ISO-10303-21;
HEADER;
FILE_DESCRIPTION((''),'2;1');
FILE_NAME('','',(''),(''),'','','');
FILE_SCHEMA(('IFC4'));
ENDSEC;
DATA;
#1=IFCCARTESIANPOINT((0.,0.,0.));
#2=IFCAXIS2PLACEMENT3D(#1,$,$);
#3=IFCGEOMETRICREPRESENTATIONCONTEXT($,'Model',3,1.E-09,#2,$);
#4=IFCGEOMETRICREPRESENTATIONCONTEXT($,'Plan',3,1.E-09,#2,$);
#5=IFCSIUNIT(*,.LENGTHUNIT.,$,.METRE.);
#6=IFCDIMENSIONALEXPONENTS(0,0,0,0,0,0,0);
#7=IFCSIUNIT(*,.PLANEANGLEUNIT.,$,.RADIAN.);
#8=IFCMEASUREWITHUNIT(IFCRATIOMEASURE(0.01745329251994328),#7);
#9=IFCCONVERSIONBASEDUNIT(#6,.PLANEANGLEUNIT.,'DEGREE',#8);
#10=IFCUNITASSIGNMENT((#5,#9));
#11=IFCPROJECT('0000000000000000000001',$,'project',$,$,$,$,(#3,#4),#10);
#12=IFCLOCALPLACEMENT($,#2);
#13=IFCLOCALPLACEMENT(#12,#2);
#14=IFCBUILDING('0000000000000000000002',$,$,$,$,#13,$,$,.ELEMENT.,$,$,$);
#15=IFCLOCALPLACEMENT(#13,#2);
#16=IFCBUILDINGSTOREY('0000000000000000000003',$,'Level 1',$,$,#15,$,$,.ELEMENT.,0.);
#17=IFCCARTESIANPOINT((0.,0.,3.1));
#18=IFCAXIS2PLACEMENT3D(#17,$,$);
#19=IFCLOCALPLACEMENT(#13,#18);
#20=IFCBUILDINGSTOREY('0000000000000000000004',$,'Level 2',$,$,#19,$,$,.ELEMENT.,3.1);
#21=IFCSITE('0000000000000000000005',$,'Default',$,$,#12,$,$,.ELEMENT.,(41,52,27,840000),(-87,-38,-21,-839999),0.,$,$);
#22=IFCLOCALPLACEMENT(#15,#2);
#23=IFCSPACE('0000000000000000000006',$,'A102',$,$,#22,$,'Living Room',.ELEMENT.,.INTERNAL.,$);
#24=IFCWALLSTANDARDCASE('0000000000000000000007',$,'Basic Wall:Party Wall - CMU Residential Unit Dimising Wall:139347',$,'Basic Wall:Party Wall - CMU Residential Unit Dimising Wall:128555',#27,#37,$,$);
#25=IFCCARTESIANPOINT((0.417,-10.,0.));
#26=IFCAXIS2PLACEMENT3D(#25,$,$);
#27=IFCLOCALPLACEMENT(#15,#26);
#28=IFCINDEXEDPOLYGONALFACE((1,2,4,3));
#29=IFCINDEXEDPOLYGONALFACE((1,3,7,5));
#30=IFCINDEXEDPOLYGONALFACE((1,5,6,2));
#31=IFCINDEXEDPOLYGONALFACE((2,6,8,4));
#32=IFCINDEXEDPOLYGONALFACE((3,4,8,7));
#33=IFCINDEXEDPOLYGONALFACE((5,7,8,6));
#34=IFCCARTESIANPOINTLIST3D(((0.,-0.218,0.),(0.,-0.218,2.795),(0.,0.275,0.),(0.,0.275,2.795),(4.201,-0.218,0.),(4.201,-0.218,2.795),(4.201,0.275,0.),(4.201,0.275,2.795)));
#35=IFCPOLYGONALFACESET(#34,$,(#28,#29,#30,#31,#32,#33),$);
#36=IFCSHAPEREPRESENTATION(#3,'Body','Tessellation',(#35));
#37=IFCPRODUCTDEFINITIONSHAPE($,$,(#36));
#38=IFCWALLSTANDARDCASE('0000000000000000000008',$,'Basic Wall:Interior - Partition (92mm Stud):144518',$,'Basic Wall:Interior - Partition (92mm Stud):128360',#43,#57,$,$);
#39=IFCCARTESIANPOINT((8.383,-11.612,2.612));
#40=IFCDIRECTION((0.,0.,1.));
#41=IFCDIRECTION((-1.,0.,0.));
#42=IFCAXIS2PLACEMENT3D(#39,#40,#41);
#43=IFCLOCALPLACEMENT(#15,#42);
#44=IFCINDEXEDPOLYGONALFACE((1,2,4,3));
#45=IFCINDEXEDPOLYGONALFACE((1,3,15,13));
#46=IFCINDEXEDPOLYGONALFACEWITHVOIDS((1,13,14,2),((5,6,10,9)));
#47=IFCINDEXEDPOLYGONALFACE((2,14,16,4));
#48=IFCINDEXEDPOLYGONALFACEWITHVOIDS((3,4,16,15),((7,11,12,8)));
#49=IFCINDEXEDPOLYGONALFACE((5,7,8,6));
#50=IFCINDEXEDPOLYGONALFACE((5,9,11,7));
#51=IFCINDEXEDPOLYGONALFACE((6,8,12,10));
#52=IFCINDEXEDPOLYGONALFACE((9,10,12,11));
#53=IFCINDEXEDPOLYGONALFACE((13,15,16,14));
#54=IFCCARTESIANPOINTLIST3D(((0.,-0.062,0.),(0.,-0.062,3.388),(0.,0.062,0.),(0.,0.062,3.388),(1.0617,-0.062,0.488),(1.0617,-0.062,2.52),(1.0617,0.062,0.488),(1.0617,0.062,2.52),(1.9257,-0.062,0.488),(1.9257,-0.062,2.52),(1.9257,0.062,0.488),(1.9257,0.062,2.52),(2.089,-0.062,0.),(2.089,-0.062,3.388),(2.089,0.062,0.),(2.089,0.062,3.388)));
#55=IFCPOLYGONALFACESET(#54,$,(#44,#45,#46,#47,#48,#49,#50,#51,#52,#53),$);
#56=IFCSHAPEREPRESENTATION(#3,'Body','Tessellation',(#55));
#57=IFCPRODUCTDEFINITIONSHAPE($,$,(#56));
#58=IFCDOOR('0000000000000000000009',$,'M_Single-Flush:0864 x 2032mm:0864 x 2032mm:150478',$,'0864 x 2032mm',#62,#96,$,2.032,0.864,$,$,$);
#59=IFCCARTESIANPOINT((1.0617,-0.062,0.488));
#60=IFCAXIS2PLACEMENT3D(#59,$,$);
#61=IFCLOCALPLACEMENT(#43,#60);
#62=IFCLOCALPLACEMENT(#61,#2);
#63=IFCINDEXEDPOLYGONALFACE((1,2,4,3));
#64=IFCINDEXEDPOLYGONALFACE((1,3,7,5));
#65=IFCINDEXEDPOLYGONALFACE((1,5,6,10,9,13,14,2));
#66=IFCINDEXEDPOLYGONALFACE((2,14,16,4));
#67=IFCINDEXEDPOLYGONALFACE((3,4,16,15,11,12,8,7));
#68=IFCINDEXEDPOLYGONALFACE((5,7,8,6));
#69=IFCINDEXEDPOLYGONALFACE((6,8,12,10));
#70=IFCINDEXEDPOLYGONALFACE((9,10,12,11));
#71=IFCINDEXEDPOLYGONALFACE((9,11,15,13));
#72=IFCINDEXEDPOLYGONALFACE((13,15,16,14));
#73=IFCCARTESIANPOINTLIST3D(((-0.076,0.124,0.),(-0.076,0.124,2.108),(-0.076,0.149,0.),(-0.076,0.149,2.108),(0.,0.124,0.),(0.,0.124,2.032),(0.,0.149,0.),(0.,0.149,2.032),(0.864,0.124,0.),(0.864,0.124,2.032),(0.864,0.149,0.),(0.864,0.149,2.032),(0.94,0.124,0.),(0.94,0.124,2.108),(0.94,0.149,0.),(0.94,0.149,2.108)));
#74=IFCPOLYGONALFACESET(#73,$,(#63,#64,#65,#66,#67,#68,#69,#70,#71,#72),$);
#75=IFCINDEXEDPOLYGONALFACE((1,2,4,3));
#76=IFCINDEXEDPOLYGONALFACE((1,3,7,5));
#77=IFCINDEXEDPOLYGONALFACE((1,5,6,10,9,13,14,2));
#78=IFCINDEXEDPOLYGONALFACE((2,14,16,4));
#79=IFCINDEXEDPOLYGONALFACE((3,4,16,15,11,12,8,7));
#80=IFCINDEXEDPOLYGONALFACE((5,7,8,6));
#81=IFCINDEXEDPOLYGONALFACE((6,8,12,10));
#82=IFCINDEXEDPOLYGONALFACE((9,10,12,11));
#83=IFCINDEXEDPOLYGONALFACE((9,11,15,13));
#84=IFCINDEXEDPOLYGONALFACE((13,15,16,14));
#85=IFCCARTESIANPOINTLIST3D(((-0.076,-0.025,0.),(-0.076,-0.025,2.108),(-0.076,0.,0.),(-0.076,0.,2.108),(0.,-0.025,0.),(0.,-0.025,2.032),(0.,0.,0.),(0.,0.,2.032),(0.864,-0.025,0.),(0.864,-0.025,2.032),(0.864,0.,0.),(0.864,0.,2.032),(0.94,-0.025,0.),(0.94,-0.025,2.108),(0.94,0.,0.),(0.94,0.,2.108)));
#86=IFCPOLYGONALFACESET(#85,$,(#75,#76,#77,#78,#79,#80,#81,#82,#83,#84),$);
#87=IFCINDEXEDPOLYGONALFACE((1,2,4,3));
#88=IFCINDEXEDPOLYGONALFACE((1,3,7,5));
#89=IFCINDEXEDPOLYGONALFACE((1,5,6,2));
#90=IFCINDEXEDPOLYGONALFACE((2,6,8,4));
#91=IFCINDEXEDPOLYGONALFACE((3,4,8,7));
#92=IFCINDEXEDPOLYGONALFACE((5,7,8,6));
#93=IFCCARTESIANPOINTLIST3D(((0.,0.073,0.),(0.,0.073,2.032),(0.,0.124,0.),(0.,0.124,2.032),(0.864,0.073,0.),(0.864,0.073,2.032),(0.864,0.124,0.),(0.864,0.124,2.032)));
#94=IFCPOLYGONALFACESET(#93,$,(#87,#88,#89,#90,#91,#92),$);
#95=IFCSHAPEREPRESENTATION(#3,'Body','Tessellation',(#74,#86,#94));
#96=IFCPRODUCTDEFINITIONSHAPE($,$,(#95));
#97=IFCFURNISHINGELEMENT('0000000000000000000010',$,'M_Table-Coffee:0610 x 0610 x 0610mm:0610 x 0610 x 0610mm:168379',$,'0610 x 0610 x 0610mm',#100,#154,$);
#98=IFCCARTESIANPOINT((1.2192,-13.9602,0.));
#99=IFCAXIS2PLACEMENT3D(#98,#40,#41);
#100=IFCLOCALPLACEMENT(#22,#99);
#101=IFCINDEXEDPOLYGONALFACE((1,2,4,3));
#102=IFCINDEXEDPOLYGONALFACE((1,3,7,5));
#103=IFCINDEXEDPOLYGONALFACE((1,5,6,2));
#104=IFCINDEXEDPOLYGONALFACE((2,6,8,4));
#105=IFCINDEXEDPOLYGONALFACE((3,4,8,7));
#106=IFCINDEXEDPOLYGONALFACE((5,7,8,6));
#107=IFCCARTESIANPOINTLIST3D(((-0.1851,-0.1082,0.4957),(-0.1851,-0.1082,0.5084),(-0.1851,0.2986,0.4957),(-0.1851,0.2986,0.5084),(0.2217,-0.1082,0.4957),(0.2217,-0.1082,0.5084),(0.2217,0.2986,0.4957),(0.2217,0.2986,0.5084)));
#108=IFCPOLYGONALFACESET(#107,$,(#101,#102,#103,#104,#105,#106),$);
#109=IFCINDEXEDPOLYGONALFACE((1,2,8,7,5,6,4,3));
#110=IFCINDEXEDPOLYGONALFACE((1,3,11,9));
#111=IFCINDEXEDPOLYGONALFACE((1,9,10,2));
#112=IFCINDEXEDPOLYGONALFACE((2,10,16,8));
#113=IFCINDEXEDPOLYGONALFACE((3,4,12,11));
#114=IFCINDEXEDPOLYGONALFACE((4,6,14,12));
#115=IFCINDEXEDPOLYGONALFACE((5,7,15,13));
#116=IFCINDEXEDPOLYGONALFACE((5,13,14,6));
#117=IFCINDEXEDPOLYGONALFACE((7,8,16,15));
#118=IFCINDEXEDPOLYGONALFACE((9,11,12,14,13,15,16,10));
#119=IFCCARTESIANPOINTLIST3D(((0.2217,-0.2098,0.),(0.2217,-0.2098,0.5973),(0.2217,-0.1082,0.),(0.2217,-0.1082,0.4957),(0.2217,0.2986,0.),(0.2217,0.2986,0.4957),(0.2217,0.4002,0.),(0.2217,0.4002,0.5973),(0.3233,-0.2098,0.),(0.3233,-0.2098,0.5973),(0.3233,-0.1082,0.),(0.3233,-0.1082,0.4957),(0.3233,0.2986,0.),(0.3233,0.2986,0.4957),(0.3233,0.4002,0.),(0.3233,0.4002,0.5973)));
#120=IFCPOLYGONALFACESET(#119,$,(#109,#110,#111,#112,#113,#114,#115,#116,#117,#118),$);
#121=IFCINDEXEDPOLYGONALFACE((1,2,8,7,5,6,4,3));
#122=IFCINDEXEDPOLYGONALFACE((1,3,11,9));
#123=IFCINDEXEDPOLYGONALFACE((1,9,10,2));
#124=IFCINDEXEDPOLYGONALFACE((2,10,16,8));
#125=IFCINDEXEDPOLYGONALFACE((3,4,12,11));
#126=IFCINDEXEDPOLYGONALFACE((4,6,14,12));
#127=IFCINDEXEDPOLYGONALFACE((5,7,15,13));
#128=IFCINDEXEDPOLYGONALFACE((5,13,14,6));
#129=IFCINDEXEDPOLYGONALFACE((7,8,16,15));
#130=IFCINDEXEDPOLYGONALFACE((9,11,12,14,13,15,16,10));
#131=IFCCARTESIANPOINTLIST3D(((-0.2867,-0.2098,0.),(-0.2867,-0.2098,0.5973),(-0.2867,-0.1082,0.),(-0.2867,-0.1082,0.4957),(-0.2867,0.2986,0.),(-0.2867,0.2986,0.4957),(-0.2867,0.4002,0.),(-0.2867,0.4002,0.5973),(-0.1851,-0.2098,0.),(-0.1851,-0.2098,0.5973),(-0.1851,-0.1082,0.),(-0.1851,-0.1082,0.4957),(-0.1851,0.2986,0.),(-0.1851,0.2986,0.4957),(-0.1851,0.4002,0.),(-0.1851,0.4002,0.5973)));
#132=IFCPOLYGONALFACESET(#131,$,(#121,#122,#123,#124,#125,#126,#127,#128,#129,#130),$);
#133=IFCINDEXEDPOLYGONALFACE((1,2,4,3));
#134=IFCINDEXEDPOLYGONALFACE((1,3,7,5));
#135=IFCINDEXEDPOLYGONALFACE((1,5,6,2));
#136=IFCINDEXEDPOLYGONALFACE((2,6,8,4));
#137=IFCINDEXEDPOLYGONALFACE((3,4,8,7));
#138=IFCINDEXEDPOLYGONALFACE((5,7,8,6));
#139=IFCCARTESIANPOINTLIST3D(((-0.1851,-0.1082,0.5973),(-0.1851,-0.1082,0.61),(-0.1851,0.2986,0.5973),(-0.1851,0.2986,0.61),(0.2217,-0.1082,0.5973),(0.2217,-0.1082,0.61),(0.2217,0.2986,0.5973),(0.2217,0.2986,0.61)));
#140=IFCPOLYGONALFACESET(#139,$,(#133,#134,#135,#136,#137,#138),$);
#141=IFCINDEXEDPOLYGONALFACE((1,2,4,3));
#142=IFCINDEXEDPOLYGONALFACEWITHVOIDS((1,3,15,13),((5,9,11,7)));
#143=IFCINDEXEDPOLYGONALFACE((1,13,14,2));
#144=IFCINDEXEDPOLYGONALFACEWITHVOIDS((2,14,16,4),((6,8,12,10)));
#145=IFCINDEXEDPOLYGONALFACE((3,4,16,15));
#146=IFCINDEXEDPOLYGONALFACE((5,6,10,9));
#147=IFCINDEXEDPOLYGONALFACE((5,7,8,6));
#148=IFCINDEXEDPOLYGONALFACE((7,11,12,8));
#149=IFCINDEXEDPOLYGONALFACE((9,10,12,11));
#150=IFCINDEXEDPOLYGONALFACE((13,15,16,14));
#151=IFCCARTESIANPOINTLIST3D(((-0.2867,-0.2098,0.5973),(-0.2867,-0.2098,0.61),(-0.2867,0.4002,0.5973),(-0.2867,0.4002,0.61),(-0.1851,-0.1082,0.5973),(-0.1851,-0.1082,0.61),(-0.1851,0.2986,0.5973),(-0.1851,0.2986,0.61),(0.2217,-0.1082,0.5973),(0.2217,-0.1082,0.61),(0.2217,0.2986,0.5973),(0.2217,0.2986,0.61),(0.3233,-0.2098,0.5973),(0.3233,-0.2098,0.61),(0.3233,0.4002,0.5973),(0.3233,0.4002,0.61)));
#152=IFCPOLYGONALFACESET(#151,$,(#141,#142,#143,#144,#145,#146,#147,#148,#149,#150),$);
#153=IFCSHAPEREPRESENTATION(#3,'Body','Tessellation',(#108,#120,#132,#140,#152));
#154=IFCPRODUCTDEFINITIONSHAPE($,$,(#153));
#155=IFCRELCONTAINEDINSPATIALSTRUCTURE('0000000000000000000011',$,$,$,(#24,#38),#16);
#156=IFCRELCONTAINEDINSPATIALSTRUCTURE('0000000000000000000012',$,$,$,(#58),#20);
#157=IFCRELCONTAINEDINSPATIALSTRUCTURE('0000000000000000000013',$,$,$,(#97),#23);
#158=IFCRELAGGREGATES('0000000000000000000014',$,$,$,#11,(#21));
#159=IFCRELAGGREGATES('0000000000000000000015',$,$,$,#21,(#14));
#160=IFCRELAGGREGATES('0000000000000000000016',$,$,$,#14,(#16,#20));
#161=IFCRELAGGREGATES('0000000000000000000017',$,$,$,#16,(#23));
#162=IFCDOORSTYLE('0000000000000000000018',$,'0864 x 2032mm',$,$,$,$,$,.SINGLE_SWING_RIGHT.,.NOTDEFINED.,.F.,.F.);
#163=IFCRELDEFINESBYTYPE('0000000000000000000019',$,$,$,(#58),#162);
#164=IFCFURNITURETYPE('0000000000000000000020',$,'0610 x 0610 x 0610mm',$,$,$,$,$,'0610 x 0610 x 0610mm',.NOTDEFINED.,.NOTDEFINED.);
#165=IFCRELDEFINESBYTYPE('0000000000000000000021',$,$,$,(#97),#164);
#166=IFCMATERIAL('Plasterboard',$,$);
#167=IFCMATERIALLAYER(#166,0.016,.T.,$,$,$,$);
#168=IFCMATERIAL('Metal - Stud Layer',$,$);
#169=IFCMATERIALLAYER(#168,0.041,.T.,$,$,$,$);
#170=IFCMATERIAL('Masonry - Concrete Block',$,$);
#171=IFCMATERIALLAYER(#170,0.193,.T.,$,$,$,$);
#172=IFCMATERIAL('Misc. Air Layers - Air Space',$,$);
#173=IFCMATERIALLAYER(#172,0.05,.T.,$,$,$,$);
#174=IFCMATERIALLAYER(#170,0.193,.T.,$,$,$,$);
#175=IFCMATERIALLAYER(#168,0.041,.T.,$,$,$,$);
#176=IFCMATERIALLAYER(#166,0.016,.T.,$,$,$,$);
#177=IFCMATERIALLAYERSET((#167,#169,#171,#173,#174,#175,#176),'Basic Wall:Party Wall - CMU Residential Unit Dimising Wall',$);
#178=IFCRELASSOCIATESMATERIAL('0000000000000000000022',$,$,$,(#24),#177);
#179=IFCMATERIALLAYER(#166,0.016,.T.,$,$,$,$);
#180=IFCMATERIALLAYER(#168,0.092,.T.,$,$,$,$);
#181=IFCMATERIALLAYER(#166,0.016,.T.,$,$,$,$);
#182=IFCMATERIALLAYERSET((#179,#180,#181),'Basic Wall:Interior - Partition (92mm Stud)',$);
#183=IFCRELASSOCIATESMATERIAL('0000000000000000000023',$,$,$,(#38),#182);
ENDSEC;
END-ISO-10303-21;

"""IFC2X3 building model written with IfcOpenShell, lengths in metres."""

from ifc_helpers import new_model, entity, si_unit, converted_unit, frame, frame_2d, origin, origin_2d_with_axis, place, context, project, spatial, polyline, rectangle, outline, extrude, clip, bounded_halfspace, source, transform, mapped, material, layer, layer_set, layer_usage, type_object, type_shapes, element, fill, save


model = new_model("IFC2X3")

# Units and contexts
model_context = context("Model", 3, precision=1e-09, world=origin())
plan_context = context("Plan", 3, precision=1e-09, world=origin())
ifc_project = project(units=[si_unit("LENGTHUNIT", "METRE"), converted_unit("PLANEANGLEUNIT", "DEGREE", entity("IfcRatioMeasure", 0.01745329251994328), si_unit("PLANEANGLEUNIT", "RADIAN"), dimensions=[0, 0, 0, 0, 0, 0, 0])], contexts=[model_context, plan_context])

# Site, building, storey
site_placement = place(None, origin())
site = spatial("IfcSite", under=ifc_project, at=site_placement, Name="Default", CompositionType="ELEMENT", RefLatitude=(41, 52, 27, 840000), RefLongitude=(-87, -38, -21, -839999), RefElevation=0.0)
building_placement = place(site_placement, origin())
building = spatial("IfcBuilding", under=site, at=building_placement, CompositionType="ELEMENT")
storey_1_placement = place(building_placement, origin())
storey_1 = spatial("IfcBuildingStorey", under=building, at=storey_1_placement, Name="Level 1", CompositionType="ELEMENT", Elevation=0.0)

# Shared definitions
ifc_material_1 = material(Name="Misc. Air Layers - Air Space")
ifc_material_2 = material(Name="Masonry - Concrete Block")
ifc_material_3 = material(Name="Metal - Stud Layer")
ifc_material_4 = material(Name="Plasterboard")

# Wall
ifc_layer_1 = layer(ifc_material_4, 0.016, ventilated=True)
ifc_layer_2 = layer(ifc_material_3, 0.041, ventilated=True)
ifc_layer_3 = layer(ifc_material_2, 0.193, ventilated=True)
ifc_layer_4 = layer(ifc_material_1, 0.05, ventilated=True)
ifc_layer_5 = layer(ifc_material_2, 0.193, ventilated=True)
ifc_layer_6 = layer(ifc_material_3, 0.041, ventilated=True)
ifc_layer_7 = layer(ifc_material_4, 0.016, ventilated=True)
ifc_layer_set_1 = layer_set([ifc_layer_1, ifc_layer_2, ifc_layer_3, ifc_layer_4, ifc_layer_5, ifc_layer_6, ifc_layer_7], Name="Basic Wall:Party Wall - CMU Residential Unit Dimising Wall")
ifc_layer_usage_1 = layer_usage(ifc_layer_set_1, "AXIS2", "NEGATIVE", 0.275)
wall_1_placement = place(storey_1_placement, frame((0.417, -10.0, 0.0)))
element("IfcWallStandardCase", 1, at=wall_1_placement, inside=storey_1, material=ifc_layer_usage_1, Name="Basic Wall:Party Wall - CMU Residential Unit Dimising Wall:139347", ObjectType="Basic Wall:Party Wall - CMU Residential Unit Dimising Wall:128555", context=model_context, shape_type="Clipping", body=[
    clip(clip(extrude(rectangle(XDim=4.201, YDim=0.55, at=frame_2d((2.1005, 0.0), x_axis=(-1.0, 0.0))), origin(), (0.0, 0.0, 1.0), 2.795), bounded_halfspace(frame((0.0, -0.218, 0.0), z_axis=(0.0, 1.0, 0.0), x_axis=(-1.0, 0.0, 0.0)), True, frame((0.0, -0.218, 0.0), z_axis=(0.0, 1.0, 0.0), x_axis=(-1.0, 0.0, 0.0)), polyline([(0.0, 0.0), (0.0, 2.795), (-4.201, 2.795), (-4.201, 0.0), (0.0, 0.0)]))), bounded_halfspace(frame((4.201, 0.275, 0.0), z_axis=(-1.0, 0.0, 0.0), x_axis=(0.0, -1.0, 0.0)), True, frame((4.201, 0.275, 0.0), z_axis=(-1.0, 0.0, 0.0), x_axis=(0.0, -1.0, 0.0)), polyline([(0.0, 0.0), (0.493, 0.0), (0.493, 2.795), (0.0, 2.795), (0.0, 0.0)]))),
])
ifc_layer_8 = layer(ifc_material_4, 0.016, ventilated=True)
ifc_layer_9 = layer(ifc_material_3, 0.092, ventilated=True)
ifc_layer_10 = layer(ifc_material_4, 0.016, ventilated=True)
ifc_layer_set_2 = layer_set([ifc_layer_8, ifc_layer_9, ifc_layer_10], Name="Basic Wall:Interior - Partition (92mm Stud)")
ifc_layer_usage_2 = layer_usage(ifc_layer_set_2, "AXIS2", "NEGATIVE", 0.062)

# Wall, opening
wall_2_placement = place(storey_1_placement, frame((8.383, -11.612, 2.612), z_axis=(0.0, 0.0, 1.0), x_axis=(-1.0, 0.0, 0.0)))
wall_2 = element("IfcWallStandardCase", 2, at=wall_2_placement, inside=storey_1, material=ifc_layer_usage_2, Name="Basic Wall:Interior - Partition (92mm Stud):144518", ObjectType="Basic Wall:Interior - Partition (92mm Stud):128360", context=model_context, shape_type="SweptSolid", body=[
    extrude(rectangle(XDim=2.089, YDim=0.124, at=frame_2d((1.0445, 0.0), x_axis=(-1.0, 0.0))), origin(), (0.0, 0.0, 1.0), 3.388),
])
opening_1_placement = place(wall_2_placement, frame((1.0617, -0.062, 0.488)))
opening_1 = element("IfcOpeningElement", 3, at=opening_1_placement, cuts=wall_2, ObjectType="Opening", context=model_context, shape_type="SweptSolid", body=[
    extrude(rectangle(XDim=0.864, YDim=2.032, at=frame_2d((1.016, 0.432), x_axis=(0.0, 1.0))), frame((0.0, 0.0, 0.0), z_axis=(0.0, 1.0, 0.0), x_axis=(0.0, 0.0, 1.0)), (0.0, 0.0, 1.0), 0.124),
])

# Shared definitions
storey_2_placement = place(building_placement, frame((0.0, 0.0, 3.1)))
storey_2 = spatial("IfcBuildingStorey", under=building, at=storey_2_placement, Name="Level 2", CompositionType="ELEMENT", Elevation=3.1)

# Door
door_style_1 = type_object("IfcDoorStyle", Name="0864 x 2032mm", ConstructionType="NOTDEFINED", OperationType="SINGLE_SWING_RIGHT", ParameterTakesPrecedence=False, Sizeable=False)
shared_shape_1 = source(origin(), model_context, "Body", "SweptSolid", [
    extrude(outline(polyline([(-0.508, -1.073), (0.508, -1.073), (0.508, 1.035), (0.432, 1.035), (0.432, -0.997), (-0.432, -0.997), (-0.432, 1.035), (-0.508, 1.035), (-0.508, -1.073)])), frame((0.432, 0.124, 1.035), z_axis=(0.0, 1.0, 0.0), x_axis=(1.0, 0.0, 0.0)), (0.0, 0.0, 1.0), 0.025),
    extrude(outline(polyline([(-1.073, -0.508), (1.035, -0.508), (1.035, -0.432), (-0.997, -0.432), (-0.997, 0.432), (1.035, 0.432), (1.035, 0.508), (-1.073, 0.508), (-1.073, -0.508)])), frame((0.432, -0.025, 1.035), z_axis=(0.0, 1.0, 0.0), x_axis=(0.0, 0.0, -1.0)), (0.0, 0.0, 1.0), 0.025),
    extrude(rectangle(XDim=0.051, YDim=0.864, at=origin_2d_with_axis()), frame((0.432, 0.0985, 0.0), z_axis=(0.0, 0.0, 1.0), x_axis=(0.0, 1.0, 0.0)), (0.0, 0.0, 1.0), 2.032),
])
type_shapes(door_style_1, [shared_shape_1])
door_1_placement = place(opening_1_placement, origin())
door_1 = element("IfcDoor", 4, at=door_1_placement, inside=storey_2, type_object=door_style_1, Name="M_Single-Flush:0864 x 2032mm:0864 x 2032mm:150478", ObjectType="0864 x 2032mm", OverallHeight=2.032, OverallWidth=0.864, context=model_context, shape_type="MappedRepresentation", body=[
    mapped(shared_shape_1, transform((0.0, 0.0, 0.0), scale=1.0)),
])
fill(opening_1, door_1)

# Shared definitions
space_1_placement = place(storey_1_placement, origin())
space_1 = spatial("IfcSpace", under=storey_1, at=space_1_placement, Name="A102", LongName="Living Room", CompositionType="ELEMENT", InteriorOrExteriorSpace="INTERNAL")

# Furnishing element
furniture_type_1 = type_object("IfcFurnitureType", Name="0610 x 0610 x 0610mm", ElementType="0610 x 0610 x 0610mm", AssemblyPlace="NOTDEFINED")
shared_shape_2 = source(origin(), model_context, "Body", "SweptSolid", [
    extrude(rectangle(XDim=0.4068, YDim=0.4068, at=origin_2d_with_axis()), frame((0.0183, 0.0952, 0.4957), z_axis=(0.0, 0.0, 1.0), x_axis=(-1.0, 0.0, 0.0)), (0.0, 0.0, 1.0), 0.0127),
    extrude(outline(polyline([(-0.2732, -0.305), (0.324, -0.305), (0.324, 0.305), (-0.2732, 0.305), (-0.2732, 0.2034), (0.2225, 0.2034), (0.2225, -0.2034), (-0.2732, -0.2034), (-0.2732, -0.305)])), frame((0.2217, 0.0952, 0.2732), z_axis=(1.0, 0.0, 0.0), x_axis=(0.0, 0.0, 1.0)), (0.0, 0.0, 1.0), 0.1016),
    extrude(outline(polyline([(-0.305, -0.3241), (0.305, -0.3241), (0.305, 0.2733), (0.2034, 0.2733), (0.2034, -0.2224), (-0.2034, -0.2224), (-0.2034, 0.2733), (-0.305, 0.2733), (-0.305, -0.3241)])), frame((-0.2867, 0.0952, 0.2733), z_axis=(1.0, 0.0, 0.0), x_axis=(0.0, -1.0, 0.0)), (0.0, 0.0, 1.0), 0.1016),
    extrude(rectangle(XDim=0.4068, YDim=0.4068, at=origin_2d_with_axis()), frame((0.0183, 0.0952, 0.5973), z_axis=(0.0, 0.0, 1.0), x_axis=(-1.0, 0.0, 0.0)), (0.0, 0.0, 1.0), 0.0127),
    extrude(outline(polyline([(-0.305, -0.305), (0.305, -0.305), (0.305, 0.305), (-0.305, 0.305), (-0.305, -0.305)]), holes=[polyline([(-0.2034, -0.2034), (-0.2034, 0.2034), (0.2034, 0.2034), (0.2034, -0.2034), (-0.2034, -0.2034)])]), frame((0.0183, 0.0952, 0.5973), z_axis=(0.0, 0.0, 1.0), x_axis=(-1.0, 0.0, 0.0)), (0.0, 0.0, 1.0), 0.0127),
])
type_shapes(furniture_type_1, [shared_shape_2])
for number, where, z_axis, x_axis, name in (
    (5, (1.2192, -13.9602, 0.0), (0.0, 0.0, 1.0), (-1.0, 0.0, 0.0), "M_Table-Coffee:0610 x 0610 x 0610mm:0610 x 0610 x 0610mm:168379"),
):
    element("IfcFurnishingElement", number, at=place(space_1_placement, frame(where, z_axis=z_axis, x_axis=x_axis)), inside=space_1, type_object=furniture_type_1, Name=name, ObjectType="0610 x 0610 x 0610mm", context=model_context, shape_type="MappedRepresentation", body=[
        mapped(shared_shape_2, transform((0.0, 0.0, 0.0), scale=1.0)),
    ])

save(model, "model.ifc")
